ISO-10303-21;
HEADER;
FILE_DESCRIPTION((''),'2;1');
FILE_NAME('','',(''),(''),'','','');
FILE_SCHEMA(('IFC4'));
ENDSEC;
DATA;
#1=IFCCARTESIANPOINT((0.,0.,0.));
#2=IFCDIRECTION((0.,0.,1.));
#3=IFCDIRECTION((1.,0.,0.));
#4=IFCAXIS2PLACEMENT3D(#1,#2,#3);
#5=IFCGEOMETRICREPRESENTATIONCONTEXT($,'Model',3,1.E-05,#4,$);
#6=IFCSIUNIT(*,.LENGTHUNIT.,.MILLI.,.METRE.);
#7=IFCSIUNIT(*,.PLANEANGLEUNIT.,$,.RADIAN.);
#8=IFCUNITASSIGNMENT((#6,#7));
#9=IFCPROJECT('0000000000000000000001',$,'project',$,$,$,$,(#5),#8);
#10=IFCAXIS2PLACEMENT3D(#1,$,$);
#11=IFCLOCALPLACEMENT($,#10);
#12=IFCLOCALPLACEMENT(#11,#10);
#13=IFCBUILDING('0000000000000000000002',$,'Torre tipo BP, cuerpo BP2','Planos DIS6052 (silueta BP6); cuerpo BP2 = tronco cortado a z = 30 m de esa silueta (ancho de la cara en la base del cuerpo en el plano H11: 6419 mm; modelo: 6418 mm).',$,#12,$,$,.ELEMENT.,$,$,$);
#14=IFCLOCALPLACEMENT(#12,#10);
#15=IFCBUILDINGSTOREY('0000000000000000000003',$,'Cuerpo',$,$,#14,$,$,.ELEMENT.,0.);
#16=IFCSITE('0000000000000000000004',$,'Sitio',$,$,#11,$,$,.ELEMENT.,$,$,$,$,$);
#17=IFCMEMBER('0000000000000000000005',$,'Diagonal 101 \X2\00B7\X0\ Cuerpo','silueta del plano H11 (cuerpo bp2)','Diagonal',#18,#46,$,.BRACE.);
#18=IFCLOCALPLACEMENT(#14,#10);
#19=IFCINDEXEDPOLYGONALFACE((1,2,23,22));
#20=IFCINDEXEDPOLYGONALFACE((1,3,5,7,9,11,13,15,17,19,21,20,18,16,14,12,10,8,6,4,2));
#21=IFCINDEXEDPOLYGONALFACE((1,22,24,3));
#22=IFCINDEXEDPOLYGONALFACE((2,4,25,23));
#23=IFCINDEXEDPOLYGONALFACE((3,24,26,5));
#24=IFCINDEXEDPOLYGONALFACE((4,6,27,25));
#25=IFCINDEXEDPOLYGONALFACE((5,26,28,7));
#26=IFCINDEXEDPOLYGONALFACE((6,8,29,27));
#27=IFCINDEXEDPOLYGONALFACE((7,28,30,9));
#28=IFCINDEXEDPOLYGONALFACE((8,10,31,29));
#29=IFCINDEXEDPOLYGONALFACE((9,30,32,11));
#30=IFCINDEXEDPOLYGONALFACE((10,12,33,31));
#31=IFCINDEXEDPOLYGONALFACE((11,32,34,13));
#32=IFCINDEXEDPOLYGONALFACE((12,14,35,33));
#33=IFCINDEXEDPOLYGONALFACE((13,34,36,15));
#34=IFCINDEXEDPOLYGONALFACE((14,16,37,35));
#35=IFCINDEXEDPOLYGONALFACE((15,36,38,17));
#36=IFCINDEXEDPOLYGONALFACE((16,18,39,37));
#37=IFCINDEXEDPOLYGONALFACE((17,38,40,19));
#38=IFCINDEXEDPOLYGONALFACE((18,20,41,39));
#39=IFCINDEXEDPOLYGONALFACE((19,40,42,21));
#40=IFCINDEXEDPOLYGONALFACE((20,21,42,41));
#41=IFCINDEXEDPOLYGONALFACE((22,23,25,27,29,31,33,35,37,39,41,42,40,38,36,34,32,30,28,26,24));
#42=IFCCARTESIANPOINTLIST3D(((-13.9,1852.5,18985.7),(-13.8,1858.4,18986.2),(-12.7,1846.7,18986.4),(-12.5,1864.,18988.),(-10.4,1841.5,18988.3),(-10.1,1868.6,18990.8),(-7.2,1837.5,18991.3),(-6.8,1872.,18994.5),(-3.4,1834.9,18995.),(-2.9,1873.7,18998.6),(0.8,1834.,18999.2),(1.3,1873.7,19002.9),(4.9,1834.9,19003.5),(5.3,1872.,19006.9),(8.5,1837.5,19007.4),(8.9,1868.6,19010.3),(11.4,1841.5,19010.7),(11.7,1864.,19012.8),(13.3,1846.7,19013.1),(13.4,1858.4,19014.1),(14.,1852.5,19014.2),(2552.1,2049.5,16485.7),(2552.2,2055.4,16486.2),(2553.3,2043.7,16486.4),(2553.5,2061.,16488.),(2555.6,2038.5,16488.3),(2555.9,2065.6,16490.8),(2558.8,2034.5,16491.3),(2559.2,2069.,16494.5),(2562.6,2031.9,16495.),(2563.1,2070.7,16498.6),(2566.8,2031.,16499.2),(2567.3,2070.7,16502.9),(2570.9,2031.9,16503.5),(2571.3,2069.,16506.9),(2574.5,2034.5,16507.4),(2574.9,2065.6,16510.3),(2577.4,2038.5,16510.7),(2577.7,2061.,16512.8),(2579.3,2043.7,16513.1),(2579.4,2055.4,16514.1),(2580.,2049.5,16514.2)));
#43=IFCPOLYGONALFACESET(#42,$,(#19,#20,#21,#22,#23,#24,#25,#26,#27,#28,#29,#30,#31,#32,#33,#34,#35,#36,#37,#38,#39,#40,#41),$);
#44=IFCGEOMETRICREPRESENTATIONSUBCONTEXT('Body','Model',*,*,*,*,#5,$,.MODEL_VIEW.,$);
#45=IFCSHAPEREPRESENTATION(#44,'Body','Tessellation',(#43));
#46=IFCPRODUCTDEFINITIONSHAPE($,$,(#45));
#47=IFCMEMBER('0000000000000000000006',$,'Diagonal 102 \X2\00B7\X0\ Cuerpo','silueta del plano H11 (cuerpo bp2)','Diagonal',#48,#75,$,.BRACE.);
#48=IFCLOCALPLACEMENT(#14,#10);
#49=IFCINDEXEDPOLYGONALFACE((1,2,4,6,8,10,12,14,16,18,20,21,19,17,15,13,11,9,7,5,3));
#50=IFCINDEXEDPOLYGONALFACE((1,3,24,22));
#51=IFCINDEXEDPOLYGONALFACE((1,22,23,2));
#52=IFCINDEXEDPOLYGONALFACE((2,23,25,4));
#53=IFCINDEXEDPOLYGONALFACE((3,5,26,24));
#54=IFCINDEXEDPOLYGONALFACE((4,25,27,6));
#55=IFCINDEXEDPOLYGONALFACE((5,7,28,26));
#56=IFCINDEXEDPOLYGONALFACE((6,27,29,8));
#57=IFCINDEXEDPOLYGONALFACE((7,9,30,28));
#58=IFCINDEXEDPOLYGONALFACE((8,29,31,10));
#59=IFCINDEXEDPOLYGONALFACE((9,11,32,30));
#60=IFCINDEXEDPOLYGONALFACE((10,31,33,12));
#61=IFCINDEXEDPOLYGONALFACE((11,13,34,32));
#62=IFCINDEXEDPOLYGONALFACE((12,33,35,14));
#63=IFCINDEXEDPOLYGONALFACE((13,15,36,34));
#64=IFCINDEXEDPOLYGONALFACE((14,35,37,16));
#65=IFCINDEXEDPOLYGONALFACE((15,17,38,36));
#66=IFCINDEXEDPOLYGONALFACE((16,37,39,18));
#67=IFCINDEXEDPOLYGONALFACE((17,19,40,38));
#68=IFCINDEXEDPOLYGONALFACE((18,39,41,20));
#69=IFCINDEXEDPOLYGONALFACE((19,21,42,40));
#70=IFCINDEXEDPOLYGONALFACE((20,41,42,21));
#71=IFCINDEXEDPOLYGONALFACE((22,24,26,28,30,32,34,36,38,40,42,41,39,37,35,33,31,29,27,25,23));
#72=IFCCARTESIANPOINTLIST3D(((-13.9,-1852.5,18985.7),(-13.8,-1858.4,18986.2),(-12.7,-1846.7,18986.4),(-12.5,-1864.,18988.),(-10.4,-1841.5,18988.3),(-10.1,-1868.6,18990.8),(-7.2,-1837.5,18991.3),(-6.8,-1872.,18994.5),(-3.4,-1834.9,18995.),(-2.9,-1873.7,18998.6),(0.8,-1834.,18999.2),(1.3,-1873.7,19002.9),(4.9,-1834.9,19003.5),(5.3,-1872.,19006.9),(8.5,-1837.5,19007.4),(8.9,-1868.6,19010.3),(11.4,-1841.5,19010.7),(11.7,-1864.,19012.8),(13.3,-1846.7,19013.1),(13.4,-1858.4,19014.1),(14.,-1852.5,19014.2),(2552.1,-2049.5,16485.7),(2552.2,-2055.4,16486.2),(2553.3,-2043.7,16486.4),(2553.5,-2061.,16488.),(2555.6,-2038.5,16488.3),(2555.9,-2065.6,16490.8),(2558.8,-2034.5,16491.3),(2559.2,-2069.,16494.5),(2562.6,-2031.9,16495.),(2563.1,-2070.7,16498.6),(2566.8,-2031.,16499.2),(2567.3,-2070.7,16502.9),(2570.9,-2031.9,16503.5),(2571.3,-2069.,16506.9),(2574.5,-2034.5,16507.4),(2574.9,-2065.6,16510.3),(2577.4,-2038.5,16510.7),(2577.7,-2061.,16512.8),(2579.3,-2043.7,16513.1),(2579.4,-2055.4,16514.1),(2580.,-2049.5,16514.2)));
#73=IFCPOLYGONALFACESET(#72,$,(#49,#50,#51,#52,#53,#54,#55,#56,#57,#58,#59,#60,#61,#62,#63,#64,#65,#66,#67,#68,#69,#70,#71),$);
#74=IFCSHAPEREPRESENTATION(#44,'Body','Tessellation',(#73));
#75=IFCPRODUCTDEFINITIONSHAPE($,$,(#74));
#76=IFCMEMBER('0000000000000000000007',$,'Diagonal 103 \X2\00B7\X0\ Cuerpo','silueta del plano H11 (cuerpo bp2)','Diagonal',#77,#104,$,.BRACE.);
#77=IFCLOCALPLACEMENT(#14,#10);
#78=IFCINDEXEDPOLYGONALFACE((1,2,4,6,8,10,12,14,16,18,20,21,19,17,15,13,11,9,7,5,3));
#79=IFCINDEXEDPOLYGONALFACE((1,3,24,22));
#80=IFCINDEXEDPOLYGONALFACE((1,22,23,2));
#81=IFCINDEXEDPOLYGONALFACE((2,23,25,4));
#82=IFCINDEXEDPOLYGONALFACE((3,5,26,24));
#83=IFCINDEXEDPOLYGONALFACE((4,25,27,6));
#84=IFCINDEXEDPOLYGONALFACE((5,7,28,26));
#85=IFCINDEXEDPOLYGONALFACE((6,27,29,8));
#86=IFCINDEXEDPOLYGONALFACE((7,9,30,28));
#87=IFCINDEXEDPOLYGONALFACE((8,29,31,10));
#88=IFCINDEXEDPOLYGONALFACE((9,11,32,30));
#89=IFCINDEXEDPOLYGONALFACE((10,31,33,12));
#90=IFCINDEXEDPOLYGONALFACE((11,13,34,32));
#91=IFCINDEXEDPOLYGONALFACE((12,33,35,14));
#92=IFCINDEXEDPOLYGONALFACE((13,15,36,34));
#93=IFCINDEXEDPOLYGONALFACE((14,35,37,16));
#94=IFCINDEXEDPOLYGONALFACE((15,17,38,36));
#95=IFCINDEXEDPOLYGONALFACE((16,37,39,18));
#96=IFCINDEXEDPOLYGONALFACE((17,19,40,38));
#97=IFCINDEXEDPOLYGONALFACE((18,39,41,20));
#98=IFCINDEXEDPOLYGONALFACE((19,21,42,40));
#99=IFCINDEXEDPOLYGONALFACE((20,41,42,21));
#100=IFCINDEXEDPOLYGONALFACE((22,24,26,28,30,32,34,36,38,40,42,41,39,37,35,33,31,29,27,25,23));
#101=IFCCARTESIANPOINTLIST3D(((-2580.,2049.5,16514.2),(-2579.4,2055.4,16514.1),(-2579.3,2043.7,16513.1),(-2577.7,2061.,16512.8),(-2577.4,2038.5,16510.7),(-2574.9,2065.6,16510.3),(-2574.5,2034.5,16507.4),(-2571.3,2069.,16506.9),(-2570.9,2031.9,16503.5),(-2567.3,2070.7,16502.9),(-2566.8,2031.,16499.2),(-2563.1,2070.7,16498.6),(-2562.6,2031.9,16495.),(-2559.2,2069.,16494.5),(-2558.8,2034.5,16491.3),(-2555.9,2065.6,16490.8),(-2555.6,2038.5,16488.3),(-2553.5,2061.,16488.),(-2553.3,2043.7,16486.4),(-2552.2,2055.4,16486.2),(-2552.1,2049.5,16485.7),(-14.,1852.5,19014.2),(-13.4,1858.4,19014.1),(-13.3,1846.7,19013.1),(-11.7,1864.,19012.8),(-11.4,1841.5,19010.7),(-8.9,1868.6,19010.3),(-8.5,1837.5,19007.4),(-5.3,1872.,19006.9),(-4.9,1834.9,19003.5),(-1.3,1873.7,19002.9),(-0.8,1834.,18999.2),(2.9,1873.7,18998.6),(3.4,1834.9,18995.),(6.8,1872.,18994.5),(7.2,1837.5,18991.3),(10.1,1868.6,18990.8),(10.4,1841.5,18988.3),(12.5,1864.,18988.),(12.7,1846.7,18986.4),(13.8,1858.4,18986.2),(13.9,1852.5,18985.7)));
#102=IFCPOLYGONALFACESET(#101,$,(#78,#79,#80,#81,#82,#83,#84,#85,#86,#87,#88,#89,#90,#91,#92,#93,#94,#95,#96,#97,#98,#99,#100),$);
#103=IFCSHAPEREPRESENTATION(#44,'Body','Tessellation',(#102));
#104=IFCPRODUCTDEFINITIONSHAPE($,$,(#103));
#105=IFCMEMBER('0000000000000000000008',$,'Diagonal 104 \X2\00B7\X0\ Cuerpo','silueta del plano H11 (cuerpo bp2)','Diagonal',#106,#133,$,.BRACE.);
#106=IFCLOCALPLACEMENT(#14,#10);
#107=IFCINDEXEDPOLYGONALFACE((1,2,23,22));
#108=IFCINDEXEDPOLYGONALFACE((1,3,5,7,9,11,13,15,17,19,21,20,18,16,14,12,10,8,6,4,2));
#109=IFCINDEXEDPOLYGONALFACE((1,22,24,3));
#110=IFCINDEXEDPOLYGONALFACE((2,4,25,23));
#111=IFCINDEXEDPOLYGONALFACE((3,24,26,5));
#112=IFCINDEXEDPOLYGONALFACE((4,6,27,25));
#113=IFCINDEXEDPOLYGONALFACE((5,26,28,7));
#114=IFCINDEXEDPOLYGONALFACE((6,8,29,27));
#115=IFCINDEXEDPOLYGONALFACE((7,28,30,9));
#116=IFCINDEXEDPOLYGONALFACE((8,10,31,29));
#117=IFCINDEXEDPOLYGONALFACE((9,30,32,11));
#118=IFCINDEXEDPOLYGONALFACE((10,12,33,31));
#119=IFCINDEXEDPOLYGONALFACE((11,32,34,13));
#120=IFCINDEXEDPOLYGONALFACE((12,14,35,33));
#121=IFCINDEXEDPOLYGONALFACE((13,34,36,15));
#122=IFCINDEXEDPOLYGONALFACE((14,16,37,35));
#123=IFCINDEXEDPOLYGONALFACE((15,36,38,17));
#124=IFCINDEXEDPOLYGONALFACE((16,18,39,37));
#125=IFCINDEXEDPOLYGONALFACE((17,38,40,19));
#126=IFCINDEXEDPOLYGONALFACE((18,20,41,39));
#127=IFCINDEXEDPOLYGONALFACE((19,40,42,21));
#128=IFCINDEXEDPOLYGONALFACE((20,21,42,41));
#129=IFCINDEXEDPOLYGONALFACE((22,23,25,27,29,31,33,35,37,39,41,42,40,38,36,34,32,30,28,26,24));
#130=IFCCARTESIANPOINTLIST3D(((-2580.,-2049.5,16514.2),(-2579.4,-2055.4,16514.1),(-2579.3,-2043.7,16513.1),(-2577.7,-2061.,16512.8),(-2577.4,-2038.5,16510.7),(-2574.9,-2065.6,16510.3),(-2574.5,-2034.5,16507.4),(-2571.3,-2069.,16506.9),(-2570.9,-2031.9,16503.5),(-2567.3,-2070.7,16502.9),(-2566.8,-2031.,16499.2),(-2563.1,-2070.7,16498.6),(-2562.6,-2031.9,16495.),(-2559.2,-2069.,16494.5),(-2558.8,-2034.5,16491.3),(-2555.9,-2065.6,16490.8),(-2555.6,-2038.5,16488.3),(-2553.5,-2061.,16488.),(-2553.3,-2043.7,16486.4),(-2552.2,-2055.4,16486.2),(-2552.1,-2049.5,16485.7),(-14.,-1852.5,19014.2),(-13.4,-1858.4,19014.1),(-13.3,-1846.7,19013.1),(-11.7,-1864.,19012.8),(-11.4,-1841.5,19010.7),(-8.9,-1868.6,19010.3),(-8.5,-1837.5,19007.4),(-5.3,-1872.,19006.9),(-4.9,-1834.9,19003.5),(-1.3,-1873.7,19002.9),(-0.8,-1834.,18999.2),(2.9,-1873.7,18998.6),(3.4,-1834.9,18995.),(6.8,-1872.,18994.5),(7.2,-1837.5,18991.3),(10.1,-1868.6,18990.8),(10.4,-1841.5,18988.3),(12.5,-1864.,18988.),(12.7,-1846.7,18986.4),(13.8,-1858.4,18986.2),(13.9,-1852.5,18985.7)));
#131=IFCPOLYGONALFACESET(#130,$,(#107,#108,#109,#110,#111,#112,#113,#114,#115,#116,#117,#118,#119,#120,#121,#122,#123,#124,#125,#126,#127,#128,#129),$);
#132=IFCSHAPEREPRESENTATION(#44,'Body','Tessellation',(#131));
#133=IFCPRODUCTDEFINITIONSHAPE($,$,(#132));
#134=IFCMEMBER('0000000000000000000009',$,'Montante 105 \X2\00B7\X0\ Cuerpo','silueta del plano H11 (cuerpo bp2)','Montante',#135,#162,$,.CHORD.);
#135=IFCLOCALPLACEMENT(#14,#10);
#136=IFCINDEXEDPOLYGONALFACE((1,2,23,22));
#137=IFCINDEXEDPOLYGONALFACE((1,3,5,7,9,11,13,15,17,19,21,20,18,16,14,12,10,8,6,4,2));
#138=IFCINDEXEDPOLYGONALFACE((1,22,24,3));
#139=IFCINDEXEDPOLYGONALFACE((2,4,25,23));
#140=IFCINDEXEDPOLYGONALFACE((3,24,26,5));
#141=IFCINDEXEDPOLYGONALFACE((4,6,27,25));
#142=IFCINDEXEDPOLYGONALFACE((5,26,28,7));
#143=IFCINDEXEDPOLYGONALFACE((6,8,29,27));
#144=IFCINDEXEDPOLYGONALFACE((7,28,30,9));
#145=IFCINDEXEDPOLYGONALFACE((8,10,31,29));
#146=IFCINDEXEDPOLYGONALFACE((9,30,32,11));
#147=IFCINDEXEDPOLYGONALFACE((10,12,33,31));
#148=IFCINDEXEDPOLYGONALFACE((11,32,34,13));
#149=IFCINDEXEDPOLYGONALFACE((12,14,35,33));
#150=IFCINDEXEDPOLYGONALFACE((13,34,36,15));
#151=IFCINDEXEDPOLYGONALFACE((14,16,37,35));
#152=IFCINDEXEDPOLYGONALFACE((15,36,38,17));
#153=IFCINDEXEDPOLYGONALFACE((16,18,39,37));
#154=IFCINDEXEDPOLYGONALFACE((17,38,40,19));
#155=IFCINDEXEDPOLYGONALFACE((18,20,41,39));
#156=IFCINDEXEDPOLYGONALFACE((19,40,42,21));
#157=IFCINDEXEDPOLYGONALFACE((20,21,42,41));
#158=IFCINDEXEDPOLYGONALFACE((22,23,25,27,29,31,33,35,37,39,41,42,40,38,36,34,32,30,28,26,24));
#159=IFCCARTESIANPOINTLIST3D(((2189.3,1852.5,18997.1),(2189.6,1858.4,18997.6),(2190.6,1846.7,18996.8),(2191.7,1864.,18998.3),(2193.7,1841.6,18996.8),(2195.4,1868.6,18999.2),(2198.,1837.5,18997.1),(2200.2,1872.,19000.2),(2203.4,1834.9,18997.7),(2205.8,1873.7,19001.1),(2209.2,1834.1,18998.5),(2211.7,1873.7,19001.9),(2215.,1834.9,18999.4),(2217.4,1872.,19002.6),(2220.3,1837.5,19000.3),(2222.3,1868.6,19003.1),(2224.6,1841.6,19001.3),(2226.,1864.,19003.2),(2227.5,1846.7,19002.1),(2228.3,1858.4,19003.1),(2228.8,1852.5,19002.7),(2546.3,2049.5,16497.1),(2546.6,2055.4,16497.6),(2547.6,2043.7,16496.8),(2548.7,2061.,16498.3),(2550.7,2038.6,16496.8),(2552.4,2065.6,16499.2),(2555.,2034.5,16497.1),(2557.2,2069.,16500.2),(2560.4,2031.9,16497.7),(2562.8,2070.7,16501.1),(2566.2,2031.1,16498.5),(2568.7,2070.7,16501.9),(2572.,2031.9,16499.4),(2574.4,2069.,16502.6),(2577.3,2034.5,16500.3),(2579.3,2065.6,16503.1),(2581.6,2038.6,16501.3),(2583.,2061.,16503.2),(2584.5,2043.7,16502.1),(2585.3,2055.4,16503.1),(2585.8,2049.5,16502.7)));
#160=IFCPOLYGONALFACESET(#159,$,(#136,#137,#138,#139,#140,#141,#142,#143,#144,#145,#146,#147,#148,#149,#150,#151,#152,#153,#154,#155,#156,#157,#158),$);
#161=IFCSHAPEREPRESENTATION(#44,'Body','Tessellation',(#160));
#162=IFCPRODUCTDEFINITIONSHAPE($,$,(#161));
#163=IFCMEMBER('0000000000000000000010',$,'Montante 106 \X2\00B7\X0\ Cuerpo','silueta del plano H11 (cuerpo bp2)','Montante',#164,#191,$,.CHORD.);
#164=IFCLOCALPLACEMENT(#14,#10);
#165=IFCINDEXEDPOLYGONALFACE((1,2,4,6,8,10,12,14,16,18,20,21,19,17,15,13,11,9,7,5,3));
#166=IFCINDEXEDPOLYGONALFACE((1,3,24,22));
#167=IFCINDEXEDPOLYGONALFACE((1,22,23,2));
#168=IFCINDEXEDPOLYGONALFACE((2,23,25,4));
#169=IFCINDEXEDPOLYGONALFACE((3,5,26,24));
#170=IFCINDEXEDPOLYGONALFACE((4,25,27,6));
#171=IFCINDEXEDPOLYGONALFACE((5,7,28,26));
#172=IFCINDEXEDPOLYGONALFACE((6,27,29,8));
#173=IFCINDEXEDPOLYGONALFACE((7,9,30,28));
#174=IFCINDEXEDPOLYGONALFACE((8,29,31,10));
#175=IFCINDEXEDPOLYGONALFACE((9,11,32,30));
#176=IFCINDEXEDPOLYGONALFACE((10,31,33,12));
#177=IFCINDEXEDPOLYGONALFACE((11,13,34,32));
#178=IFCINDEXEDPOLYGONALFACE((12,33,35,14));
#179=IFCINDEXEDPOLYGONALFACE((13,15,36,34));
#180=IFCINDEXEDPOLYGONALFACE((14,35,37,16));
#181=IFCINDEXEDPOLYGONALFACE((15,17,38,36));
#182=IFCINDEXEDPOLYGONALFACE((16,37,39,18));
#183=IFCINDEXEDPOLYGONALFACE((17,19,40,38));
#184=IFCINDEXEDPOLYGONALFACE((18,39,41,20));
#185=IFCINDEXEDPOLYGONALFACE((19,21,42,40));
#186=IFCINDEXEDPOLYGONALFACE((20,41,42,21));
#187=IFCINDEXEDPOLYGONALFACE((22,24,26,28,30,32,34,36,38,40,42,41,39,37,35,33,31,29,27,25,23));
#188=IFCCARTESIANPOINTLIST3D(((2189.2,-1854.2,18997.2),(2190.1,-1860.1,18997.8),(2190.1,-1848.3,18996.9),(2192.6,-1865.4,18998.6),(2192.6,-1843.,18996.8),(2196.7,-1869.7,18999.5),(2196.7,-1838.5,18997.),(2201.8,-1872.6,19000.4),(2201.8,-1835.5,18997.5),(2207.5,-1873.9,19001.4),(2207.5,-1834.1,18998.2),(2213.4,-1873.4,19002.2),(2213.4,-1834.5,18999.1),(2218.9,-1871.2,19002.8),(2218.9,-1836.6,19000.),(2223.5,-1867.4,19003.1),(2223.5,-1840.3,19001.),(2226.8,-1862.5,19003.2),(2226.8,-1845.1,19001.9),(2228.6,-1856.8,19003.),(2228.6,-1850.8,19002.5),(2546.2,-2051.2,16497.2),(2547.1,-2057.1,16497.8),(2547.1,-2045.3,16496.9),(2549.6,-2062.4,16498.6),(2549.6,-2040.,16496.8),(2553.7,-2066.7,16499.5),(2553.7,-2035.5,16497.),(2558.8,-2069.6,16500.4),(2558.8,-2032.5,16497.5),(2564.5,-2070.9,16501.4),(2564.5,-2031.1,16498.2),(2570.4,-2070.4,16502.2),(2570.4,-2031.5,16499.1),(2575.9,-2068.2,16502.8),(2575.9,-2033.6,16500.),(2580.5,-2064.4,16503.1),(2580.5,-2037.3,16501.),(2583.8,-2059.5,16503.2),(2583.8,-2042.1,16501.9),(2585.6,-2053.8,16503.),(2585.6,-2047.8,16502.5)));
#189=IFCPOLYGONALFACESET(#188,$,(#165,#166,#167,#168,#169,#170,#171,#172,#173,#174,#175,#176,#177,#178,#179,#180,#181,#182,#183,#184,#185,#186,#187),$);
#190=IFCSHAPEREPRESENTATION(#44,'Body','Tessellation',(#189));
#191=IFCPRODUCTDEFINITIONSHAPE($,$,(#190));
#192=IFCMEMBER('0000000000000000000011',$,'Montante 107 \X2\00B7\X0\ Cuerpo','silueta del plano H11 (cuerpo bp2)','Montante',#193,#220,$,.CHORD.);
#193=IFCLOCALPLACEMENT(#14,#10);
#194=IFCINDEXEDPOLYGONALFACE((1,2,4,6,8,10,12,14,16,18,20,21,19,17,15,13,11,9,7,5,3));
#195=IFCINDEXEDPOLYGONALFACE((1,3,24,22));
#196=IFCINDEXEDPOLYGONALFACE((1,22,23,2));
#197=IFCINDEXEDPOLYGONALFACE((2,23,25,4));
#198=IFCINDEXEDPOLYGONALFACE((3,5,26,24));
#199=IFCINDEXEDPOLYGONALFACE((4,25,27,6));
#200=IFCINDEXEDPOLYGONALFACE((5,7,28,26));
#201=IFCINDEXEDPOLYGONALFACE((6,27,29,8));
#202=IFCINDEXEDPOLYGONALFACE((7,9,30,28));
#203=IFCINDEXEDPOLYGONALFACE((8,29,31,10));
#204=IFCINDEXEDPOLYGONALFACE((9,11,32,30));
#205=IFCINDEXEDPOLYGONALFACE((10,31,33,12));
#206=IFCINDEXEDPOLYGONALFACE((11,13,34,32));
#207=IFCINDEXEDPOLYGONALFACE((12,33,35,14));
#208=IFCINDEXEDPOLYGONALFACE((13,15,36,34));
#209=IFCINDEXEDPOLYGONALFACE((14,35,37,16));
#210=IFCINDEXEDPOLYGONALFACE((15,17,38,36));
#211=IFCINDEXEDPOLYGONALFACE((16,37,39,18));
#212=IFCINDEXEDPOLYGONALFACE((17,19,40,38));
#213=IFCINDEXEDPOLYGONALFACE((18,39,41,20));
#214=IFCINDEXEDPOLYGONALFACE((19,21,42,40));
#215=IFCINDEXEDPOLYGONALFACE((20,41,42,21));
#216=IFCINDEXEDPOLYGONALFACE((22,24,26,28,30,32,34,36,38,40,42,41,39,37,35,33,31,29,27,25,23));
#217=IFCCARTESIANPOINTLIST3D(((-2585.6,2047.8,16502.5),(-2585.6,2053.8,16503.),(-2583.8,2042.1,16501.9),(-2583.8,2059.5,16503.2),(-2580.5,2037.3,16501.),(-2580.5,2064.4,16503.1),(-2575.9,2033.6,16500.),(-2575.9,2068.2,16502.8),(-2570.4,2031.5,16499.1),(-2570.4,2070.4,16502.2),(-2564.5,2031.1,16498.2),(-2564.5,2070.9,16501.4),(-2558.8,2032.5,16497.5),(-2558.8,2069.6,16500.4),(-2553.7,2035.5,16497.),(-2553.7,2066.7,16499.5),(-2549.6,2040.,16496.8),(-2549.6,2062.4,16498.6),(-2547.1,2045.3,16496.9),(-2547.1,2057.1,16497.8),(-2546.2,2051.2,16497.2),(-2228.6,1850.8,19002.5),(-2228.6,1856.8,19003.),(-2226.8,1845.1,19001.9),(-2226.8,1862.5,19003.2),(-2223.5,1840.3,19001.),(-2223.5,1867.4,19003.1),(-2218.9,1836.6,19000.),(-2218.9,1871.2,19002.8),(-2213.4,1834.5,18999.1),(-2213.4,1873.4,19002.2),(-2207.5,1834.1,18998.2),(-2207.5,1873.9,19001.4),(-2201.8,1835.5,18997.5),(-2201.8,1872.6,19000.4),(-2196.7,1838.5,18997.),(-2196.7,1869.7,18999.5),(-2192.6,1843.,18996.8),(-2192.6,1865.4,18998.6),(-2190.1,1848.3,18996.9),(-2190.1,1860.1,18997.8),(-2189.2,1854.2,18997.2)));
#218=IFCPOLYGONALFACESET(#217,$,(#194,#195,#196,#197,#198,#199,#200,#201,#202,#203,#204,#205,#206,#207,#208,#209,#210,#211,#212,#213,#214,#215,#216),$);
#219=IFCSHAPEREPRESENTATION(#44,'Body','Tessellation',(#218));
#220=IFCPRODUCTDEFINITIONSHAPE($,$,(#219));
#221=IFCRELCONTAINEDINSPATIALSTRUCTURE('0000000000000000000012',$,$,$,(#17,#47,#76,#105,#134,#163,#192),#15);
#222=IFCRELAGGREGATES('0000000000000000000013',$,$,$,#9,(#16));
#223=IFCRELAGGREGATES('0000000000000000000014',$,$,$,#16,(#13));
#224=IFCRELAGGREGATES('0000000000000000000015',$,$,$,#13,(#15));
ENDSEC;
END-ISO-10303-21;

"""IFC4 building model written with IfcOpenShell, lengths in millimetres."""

from ifc_helpers import new_model, si_unit, frame, origin, origin_with_axes, place, context, subcontext, project, spatial, circle, extrude, element, save


model = new_model("IFC4")

# Units and contexts
model_context = context("Model", 3, precision=1e-05, world=origin_with_axes())
body_context = subcontext(model_context, "Body", "Model", "MODEL_VIEW")
ifc_project = project(units=[si_unit("LENGTHUNIT", "METRE", prefix="MILLI"), si_unit("PLANEANGLEUNIT", "RADIAN")], contexts=[model_context])

# Site, building, storey
site_placement = place(None, origin())
site = spatial("IfcSite", under=ifc_project, at=site_placement, Name="Sitio", CompositionType="ELEMENT")
building_placement = place(site_placement, origin())
building = spatial("IfcBuilding", under=site, at=building_placement, Name="Torre tipo BP, cuerpo BP2", Description="Planos DIS6052 (silueta BP6); cuerpo BP2 = tronco cortado a z = 30 m de esa silueta (ancho de la cara en la base del cuerpo en el plano H11: 6419 mm; modelo: 6418 mm).", CompositionType="ELEMENT")
storey_placement = place(building_placement, origin())
storey = spatial("IfcBuildingStorey", under=building, at=storey_placement, Name="Cuerpo", CompositionType="ELEMENT", Elevation=0.0)

# Members
for number, where, z_axis, x_axis, name in (
    (1, (0.0, 1854.0, 19000.0), (0.715178, 0.054906, -0.696783), (0.039327, -0.998492, -0.038316), "Diagonal 101 · Cuerpo"),
    (2, (0.0, -1854.0, 19000.0), (0.715178, -0.054906, -0.696783), (0.039327, 0.998492, -0.038316), "Diagonal 102 · Cuerpo"),
    (3, (0.0, 1854.0, 19000.0), (-0.715178, 0.054906, -0.696783), (-0.039327, -0.998492, -0.038316), "Diagonal 103 · Cuerpo"),
    (4, (0.0, -1854.0, 19000.0), (-0.715178, -0.054906, -0.696783), (-0.039327, 0.998492, -0.038316), "Diagonal 104 · Cuerpo"),
):
    element("IfcMember", number, at=place(storey_placement, frame(where, z_axis=z_axis, x_axis=x_axis)), inside=storey, Name=name, Description="silueta del plano H11 (cuerpo bp2)", ObjectType="Diagonal", PredefinedType="BRACE", context=body_context, shape_type="SweptSolid", body=[
        extrude(circle(Radius=20.0), None, (0.0, 0.0, 1.0), 3587.9),
    ])
for number, where, z_axis, x_axis, name in (
    (5, (2209.0, 1854.0, 19000.0), (0.140938, 0.077772, -0.986959), (0.010994, -0.996971, -0.076991), "Montante 105 · Cuerpo"),
    (6, (2209.0, -1854.0, 19000.0), (0.140938, -0.077772, -0.986959), (-0.990018, -0.011072, -0.140502), "Montante 106 · Cuerpo"),
    (7, (-2209.0, 1854.0, 19000.0), (-0.140938, 0.077772, -0.986959), (0.990018, 0.011072, -0.140502), "Montante 107 · Cuerpo"),
):
    element("IfcMember", number, at=place(storey_placement, frame(where, z_axis=z_axis, x_axis=x_axis)), inside=storey, Name=name, Description="silueta del plano H11 (cuerpo bp2)", ObjectType="Montante", PredefinedType="CHORD", context=body_context, shape_type="SweptSolid", body=[
        extrude(circle(Radius=20.0), None, (0.0, 0.0, 1.0), 2533.0),
    ])

save(model, "model.ifc")
